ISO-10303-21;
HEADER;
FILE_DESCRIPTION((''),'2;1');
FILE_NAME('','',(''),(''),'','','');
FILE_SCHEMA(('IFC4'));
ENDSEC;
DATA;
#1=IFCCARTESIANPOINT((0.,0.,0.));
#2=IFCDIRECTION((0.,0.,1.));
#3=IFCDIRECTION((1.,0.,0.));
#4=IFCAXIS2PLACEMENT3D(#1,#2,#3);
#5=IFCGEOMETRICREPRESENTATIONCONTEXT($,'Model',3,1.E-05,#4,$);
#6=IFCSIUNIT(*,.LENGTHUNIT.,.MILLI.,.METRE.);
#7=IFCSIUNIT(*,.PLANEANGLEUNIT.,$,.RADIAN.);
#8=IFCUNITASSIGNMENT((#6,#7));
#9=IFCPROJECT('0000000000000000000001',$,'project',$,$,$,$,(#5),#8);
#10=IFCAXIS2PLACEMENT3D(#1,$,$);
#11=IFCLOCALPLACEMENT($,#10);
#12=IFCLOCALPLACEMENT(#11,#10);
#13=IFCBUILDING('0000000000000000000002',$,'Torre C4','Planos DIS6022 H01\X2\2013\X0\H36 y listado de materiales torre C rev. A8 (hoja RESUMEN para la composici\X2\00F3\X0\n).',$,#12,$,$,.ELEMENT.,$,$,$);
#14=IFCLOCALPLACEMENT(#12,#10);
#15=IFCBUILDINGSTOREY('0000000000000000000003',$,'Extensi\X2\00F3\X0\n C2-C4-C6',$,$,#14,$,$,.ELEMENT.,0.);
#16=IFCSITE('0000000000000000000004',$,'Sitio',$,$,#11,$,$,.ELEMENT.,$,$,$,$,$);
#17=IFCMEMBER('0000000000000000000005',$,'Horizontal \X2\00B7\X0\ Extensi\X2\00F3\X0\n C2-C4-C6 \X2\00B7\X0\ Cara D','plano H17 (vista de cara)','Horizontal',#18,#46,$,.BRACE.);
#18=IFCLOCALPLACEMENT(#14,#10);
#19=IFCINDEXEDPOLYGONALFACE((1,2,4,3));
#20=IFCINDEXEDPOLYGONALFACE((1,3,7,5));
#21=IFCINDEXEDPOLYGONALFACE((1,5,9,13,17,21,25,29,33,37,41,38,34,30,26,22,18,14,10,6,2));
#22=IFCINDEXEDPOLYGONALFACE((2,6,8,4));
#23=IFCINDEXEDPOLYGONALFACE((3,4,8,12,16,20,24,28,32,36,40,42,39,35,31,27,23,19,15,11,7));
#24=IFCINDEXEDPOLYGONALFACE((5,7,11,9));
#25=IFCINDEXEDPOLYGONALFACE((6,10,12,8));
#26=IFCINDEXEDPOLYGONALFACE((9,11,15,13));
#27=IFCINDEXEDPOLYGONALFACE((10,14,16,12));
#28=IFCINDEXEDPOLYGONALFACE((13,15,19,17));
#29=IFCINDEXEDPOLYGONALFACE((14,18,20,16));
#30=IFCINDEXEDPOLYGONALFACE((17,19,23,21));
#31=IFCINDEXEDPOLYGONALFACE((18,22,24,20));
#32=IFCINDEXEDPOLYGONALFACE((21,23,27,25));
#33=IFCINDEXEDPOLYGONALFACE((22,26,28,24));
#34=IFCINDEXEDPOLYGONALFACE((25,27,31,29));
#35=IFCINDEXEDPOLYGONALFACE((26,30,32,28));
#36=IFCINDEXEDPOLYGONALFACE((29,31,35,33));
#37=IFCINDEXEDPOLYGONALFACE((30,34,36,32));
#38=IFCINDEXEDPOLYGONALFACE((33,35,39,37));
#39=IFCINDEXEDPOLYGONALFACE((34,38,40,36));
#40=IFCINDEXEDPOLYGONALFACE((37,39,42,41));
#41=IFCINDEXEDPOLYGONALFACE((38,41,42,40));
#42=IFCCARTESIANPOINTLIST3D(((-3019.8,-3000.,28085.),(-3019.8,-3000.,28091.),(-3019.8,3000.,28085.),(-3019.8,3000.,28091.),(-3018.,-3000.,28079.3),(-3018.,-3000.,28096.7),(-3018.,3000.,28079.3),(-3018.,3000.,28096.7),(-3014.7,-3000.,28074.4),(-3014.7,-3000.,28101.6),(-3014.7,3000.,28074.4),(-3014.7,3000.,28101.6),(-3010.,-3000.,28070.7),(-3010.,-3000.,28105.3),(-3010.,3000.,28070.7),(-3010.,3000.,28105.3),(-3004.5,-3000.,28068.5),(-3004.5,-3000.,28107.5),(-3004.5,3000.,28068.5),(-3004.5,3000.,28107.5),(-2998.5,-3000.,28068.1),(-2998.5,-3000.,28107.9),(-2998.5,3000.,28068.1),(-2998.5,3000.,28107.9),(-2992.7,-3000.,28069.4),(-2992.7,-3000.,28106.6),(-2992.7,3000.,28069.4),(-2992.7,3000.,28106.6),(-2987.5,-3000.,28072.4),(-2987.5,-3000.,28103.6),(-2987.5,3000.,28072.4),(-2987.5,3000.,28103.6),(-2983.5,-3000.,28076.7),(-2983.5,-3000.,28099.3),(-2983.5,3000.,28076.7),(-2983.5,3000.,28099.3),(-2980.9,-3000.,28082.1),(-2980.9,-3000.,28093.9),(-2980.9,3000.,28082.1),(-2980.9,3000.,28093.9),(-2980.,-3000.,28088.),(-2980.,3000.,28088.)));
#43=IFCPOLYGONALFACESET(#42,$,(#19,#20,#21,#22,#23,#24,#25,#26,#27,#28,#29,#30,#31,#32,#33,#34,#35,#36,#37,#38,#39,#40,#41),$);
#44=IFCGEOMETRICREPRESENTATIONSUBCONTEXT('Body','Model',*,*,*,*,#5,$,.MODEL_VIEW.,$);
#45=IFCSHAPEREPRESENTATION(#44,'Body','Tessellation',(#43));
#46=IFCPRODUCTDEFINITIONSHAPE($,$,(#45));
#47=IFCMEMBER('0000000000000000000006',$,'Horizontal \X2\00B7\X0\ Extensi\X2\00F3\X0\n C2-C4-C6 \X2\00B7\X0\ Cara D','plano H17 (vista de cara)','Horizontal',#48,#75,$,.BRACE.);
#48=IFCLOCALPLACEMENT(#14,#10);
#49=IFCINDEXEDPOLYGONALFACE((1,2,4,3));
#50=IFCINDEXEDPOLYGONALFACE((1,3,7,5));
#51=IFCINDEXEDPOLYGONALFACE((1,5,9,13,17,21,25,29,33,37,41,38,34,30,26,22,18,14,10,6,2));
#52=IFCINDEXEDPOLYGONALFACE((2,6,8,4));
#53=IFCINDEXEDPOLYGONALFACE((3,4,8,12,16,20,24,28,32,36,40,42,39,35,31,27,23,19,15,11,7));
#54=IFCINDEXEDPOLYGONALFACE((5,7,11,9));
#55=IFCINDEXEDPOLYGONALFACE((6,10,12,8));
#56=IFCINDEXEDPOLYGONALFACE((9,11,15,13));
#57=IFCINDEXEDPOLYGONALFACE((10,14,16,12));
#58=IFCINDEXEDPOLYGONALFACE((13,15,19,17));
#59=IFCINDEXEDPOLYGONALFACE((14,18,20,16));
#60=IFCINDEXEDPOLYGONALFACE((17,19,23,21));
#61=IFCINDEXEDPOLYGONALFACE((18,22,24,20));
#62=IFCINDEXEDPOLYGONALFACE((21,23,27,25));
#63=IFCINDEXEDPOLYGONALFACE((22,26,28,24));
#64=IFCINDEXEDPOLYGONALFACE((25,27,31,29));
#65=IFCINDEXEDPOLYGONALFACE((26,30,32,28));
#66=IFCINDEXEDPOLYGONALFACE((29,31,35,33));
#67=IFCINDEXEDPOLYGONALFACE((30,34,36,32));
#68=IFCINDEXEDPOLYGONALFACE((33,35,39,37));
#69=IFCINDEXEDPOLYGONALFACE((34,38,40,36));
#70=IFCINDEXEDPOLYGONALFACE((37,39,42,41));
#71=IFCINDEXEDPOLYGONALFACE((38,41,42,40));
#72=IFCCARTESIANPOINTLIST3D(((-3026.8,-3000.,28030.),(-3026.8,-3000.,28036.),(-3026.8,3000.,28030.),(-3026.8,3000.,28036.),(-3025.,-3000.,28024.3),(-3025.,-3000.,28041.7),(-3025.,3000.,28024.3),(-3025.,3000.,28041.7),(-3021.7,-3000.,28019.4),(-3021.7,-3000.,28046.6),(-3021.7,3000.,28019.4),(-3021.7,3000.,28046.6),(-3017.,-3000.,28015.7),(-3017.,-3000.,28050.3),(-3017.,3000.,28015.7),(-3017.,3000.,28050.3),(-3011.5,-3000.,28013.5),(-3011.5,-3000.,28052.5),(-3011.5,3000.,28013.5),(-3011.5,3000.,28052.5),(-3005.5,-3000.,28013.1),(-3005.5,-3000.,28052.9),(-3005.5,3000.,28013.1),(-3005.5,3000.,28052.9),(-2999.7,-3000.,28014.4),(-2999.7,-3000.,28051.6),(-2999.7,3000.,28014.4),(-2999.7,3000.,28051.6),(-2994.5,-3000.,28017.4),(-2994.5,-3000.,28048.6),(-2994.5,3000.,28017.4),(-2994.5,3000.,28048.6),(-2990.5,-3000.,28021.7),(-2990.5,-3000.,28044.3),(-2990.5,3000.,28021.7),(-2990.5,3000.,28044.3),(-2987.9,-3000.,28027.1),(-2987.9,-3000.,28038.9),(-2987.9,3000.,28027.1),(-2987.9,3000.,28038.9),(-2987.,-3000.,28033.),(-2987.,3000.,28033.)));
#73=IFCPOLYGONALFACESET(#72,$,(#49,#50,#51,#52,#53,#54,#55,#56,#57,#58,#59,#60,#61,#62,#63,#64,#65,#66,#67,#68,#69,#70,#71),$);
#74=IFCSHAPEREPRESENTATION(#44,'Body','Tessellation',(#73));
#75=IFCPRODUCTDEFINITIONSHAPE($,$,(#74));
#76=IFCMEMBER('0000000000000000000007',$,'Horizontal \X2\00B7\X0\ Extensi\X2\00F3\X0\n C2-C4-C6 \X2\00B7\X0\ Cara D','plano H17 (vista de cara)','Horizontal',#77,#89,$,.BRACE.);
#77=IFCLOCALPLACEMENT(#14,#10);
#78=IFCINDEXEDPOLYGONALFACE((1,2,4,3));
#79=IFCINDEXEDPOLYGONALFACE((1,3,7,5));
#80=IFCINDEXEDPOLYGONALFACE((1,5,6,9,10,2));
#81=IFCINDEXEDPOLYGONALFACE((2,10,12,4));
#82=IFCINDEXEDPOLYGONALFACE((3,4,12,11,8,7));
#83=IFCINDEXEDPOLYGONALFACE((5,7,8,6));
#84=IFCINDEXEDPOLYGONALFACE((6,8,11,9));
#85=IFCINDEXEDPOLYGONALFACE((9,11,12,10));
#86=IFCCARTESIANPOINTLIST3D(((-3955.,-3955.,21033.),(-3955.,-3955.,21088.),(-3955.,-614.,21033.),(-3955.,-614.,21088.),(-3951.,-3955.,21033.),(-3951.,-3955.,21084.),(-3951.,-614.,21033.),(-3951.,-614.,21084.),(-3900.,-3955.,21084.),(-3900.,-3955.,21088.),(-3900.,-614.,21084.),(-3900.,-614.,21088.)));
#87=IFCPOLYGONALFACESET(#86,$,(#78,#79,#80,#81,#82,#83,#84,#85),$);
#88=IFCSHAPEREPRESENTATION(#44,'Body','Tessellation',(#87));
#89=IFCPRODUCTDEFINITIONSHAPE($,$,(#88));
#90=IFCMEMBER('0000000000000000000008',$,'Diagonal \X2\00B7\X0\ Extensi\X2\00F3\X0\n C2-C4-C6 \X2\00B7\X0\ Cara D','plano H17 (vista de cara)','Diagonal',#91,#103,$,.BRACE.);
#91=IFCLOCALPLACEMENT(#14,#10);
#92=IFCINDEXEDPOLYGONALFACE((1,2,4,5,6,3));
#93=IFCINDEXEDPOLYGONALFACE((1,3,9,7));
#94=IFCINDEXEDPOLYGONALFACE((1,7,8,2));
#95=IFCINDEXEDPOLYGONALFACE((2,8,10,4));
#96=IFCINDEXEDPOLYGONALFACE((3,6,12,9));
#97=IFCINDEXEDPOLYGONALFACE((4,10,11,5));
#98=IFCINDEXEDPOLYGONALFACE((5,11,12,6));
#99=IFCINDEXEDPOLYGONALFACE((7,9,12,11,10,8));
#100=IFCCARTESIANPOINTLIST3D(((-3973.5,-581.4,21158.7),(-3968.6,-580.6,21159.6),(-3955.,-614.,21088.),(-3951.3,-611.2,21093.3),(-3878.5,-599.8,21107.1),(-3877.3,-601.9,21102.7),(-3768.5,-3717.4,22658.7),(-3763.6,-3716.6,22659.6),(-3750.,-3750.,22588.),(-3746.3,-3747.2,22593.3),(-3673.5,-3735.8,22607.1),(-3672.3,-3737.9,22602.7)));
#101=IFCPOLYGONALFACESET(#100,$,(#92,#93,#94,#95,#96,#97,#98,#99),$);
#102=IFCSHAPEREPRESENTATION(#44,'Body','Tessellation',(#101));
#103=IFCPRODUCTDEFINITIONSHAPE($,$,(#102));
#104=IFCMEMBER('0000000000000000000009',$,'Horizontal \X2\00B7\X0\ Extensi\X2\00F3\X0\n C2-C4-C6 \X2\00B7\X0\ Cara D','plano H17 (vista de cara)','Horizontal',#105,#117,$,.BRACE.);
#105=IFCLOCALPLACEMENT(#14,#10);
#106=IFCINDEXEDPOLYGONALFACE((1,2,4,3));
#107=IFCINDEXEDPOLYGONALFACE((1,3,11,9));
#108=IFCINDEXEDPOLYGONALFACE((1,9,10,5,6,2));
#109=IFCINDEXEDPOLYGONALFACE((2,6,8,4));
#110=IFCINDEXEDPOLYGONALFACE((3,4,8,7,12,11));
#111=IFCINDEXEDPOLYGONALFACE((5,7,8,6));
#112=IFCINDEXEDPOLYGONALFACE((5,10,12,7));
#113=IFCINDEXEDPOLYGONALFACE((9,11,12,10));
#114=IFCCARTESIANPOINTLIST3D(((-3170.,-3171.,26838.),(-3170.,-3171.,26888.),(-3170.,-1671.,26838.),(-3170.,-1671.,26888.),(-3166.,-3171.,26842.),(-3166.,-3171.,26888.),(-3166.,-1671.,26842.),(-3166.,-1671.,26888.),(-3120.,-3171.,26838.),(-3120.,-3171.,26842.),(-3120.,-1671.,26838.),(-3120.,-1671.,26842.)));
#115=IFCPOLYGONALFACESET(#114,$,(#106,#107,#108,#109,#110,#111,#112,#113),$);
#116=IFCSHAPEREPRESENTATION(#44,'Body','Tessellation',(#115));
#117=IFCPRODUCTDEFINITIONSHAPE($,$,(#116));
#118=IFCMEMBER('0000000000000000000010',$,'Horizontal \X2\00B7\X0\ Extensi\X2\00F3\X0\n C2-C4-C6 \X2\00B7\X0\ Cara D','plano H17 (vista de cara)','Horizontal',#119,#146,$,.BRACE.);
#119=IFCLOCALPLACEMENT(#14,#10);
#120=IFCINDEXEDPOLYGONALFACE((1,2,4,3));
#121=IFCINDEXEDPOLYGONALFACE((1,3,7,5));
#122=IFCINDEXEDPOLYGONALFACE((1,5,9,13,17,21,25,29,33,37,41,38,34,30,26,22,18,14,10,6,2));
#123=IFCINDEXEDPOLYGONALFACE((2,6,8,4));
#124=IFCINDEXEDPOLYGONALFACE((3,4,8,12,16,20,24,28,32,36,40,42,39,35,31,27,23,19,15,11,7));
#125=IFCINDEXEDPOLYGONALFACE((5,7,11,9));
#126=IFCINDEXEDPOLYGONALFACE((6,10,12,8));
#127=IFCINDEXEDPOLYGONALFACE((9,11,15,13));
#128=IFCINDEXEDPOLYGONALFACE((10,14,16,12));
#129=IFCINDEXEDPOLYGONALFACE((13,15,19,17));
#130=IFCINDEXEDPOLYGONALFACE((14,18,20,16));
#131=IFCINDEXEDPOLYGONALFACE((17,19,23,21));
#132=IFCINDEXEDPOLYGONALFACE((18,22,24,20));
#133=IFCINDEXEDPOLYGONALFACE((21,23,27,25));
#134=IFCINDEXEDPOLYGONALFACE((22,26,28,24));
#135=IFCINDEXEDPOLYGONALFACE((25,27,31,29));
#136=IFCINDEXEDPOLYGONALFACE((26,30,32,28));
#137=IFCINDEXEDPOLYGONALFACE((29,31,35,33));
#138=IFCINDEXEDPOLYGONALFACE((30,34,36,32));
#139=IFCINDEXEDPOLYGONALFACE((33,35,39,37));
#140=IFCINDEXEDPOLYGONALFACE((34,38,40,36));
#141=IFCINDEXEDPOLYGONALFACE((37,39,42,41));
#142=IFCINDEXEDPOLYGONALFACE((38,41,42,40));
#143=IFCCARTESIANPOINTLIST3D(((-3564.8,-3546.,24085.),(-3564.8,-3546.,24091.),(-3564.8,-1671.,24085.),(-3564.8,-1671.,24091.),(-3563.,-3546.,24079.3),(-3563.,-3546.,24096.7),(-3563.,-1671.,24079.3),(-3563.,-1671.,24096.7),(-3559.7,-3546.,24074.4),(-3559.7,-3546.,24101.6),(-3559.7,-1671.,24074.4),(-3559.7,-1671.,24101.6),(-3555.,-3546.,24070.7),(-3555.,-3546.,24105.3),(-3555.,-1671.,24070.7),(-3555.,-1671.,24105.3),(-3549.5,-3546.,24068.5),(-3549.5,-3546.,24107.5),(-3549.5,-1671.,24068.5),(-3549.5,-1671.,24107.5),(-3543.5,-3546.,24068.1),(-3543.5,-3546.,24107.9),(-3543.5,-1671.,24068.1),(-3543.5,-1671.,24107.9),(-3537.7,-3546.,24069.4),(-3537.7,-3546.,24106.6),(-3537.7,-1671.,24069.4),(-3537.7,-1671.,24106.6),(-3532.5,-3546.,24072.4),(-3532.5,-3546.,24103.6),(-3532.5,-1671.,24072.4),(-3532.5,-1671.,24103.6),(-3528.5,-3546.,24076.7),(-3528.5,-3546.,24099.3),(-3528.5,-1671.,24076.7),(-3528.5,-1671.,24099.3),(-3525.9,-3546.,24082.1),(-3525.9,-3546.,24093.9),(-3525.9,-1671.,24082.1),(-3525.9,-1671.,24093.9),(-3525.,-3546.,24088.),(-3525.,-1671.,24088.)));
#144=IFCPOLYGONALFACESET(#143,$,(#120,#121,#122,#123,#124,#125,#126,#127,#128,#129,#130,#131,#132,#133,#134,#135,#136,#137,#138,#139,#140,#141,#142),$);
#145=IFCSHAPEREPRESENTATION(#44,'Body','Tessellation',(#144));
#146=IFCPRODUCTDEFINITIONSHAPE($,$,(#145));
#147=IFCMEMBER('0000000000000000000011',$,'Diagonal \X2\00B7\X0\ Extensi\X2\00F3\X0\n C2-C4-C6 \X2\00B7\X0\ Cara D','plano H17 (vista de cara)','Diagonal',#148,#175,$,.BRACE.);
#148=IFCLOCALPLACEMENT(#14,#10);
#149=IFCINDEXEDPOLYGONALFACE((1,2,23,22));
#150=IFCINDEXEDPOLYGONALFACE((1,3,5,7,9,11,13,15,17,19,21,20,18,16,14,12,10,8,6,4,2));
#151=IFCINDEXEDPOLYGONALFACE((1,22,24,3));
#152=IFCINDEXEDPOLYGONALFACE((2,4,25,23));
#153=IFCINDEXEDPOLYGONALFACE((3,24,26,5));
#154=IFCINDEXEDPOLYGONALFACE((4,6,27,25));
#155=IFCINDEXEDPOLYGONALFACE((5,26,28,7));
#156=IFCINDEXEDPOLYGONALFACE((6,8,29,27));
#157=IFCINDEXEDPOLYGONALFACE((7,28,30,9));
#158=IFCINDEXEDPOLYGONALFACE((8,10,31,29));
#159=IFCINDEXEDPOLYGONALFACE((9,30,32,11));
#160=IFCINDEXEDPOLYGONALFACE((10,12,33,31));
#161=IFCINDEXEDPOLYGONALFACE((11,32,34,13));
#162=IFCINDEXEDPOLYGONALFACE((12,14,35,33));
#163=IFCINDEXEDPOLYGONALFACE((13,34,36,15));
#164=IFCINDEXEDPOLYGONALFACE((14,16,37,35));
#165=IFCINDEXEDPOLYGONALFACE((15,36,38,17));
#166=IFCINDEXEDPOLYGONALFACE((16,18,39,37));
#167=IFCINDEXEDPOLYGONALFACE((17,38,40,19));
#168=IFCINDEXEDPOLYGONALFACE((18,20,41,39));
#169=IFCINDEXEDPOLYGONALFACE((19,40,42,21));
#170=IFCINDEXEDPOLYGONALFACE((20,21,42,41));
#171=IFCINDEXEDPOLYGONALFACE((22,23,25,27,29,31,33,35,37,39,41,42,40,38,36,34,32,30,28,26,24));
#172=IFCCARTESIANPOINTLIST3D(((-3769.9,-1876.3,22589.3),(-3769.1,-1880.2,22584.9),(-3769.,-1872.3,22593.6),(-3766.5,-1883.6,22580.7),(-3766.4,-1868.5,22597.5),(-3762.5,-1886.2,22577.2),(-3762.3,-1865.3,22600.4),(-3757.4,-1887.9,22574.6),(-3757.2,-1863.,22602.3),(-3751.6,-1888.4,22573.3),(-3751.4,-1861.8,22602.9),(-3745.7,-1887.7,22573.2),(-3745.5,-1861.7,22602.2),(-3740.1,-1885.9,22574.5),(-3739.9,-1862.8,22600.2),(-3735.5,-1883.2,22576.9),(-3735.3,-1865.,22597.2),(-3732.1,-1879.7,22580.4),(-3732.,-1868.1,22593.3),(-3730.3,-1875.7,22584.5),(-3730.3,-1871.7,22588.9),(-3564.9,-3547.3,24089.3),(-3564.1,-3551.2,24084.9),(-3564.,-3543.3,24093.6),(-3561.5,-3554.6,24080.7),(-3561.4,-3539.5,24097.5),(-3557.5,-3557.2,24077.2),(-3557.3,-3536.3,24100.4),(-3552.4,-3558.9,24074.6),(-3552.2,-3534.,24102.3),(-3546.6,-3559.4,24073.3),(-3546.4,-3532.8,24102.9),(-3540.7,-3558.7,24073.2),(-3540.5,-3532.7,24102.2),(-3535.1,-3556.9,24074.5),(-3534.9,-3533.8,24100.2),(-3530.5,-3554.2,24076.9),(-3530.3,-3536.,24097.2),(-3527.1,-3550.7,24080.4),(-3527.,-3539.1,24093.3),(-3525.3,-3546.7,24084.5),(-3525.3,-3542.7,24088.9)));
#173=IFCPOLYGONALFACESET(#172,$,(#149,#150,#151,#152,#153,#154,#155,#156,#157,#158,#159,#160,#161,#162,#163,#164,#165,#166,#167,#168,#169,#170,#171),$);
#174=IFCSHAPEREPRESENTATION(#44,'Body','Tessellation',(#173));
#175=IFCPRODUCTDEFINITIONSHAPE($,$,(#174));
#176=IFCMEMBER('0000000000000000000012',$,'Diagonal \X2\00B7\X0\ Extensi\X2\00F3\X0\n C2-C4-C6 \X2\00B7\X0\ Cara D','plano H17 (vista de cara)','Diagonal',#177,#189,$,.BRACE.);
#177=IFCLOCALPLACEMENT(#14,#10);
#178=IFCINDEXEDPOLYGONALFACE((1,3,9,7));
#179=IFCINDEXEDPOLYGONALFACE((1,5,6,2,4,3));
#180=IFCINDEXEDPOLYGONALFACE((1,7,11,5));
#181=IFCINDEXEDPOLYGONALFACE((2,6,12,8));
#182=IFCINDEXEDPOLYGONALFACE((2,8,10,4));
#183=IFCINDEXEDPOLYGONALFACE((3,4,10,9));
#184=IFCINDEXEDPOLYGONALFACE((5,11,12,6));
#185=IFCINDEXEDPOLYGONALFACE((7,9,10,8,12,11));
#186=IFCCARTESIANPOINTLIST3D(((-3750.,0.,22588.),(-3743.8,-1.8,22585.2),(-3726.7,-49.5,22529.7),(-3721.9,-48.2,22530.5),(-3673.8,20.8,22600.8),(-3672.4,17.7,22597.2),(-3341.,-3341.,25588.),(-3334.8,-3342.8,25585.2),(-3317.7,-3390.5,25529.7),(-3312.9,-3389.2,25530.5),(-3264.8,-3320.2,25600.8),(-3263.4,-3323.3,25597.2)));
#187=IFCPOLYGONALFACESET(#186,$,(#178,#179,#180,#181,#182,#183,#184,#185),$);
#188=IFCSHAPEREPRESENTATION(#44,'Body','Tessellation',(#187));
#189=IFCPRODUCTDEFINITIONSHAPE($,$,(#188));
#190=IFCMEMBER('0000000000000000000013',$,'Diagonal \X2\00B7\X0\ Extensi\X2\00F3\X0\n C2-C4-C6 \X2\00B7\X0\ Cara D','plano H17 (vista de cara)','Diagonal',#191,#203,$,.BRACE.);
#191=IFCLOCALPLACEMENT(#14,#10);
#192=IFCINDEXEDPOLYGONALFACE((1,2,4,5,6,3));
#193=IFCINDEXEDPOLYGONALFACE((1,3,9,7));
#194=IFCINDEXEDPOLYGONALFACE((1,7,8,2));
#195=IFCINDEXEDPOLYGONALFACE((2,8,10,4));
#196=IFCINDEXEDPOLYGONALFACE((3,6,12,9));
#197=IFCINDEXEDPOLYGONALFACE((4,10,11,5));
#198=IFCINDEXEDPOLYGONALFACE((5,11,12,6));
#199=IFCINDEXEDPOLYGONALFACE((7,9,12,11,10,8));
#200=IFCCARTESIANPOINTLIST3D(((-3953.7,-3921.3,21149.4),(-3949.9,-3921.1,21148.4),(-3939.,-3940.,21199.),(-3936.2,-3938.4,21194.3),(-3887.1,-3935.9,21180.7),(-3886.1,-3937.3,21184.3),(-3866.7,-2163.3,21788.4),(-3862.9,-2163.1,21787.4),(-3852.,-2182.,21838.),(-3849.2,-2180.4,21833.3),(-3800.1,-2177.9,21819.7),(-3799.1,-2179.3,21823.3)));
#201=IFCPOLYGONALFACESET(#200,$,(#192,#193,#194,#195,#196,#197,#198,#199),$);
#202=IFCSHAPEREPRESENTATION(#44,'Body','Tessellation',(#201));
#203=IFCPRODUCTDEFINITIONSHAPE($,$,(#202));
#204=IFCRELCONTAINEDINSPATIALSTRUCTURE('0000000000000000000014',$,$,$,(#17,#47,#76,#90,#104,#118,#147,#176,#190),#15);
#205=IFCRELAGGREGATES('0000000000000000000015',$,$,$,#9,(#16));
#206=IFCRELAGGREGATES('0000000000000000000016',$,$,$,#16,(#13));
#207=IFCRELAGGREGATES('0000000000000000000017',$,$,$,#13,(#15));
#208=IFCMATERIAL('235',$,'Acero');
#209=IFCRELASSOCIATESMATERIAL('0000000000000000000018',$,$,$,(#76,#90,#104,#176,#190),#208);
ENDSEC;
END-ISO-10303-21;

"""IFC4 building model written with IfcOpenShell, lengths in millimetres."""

from ifc_helpers import new_model, si_unit, frame, frame_2d, origin, origin_with_axes, place, context, subcontext, project, spatial, circle, l_section, extrude, material, element, save


model = new_model("IFC4")

# Units and contexts
model_context = context("Model", 3, precision=1e-05, world=origin_with_axes())
body_context = subcontext(model_context, "Body", "Model", "MODEL_VIEW")
ifc_project = project(units=[si_unit("LENGTHUNIT", "METRE", prefix="MILLI"), si_unit("PLANEANGLEUNIT", "RADIAN")], contexts=[model_context])

# Site, building, storey
site_placement = place(None, origin())
site = spatial("IfcSite", under=ifc_project, at=site_placement, Name="Sitio", CompositionType="ELEMENT")
building_placement = place(site_placement, origin())
building = spatial("IfcBuilding", under=site, at=building_placement, Name="Torre C4", Description="Planos DIS6022 H01–H36 y listado de materiales torre C rev. A8 (hoja RESUMEN para la composición).", CompositionType="ELEMENT")
storey_placement = place(building_placement, origin())
storey = spatial("IfcBuildingStorey", under=building, at=storey_placement, Name="Extensión C2-C4-C6", CompositionType="ELEMENT", Elevation=0.0)

# Members
ifc_material_1 = material(Name="235", Category="Acero")
for number, where, z_axis, x_axis, name in (
    (1, (-3000.0, -3000.0, 28088.0), (0.0, 1.0, 0.0), (1.0, 0.0, 0.0), "Horizontal · Extensión C2-C4-C6 · Cara D"),
    (2, (-3007.0, -3000.0, 28033.0), (0.0, 1.0, 0.0), (1.0, 0.0, 0.0), "Horizontal · Extensión C2-C4-C6 · Cara D"),
):
    element("IfcMember", number, at=place(storey_placement, frame(where, z_axis=z_axis, x_axis=x_axis)), inside=storey, Name=name, Description="plano H17 (vista de cara)", ObjectType="Horizontal", PredefinedType="BRACE", context=body_context, shape_type="SweptSolid", body=[
        extrude(circle(Radius=20.0), None, (0.0, 0.0, 1.0), 6000.0),
    ])
member_1_placement = place(storey_placement, frame((-3955.0, -3955.0, 21088.0), z_axis=(0.0, 1.0, 0.0), x_axis=(1.0, 0.0, 0.0)))
element("IfcMember", 3, at=member_1_placement, inside=storey, material=ifc_material_1, Name="Horizontal · Extensión C2-C4-C6 · Cara D", Description="plano H17 (vista de cara)", ObjectType="Horizontal", PredefinedType="BRACE", context=body_context, shape_type="SweptSolid", body=[
    extrude(l_section(Depth=55.0, Width=55.0, Thickness=4.0, at=frame_2d((27.5, 27.5))), None, (0.0, 0.0, 1.0), 3341.0),
])
member_2_placement = place(storey_placement, frame((-3955.0, -614.0, 21088.0), z_axis=(0.058869, -0.90055, 0.430748), x_axis=(0.971215, 0.151437, 0.183871)))
element("IfcMember", 4, at=member_2_placement, inside=storey, material=ifc_material_1, Name="Diagonal · Extensión C2-C4-C6 · Cara D", Description="plano H17 (vista de cara)", ObjectType="Diagonal", PredefinedType="BRACE", context=body_context, shape_type="SweptSolid", body=[
    extrude(l_section(Depth=80.0, Width=80.0, Thickness=5.0, at=frame_2d((40.0, 40.0))), None, (0.0, 0.0, 1.0), 3482.3),
])
member_3_placement = place(storey_placement, frame((-3170.0, -1671.0, 26838.0), z_axis=(0.0, -1.0, 0.0), x_axis=(1.0, 0.0, 0.0)))
element("IfcMember", 5, at=member_3_placement, inside=storey, material=ifc_material_1, Name="Horizontal · Extensión C2-C4-C6 · Cara D", Description="plano H17 (vista de cara)", ObjectType="Horizontal", PredefinedType="BRACE", context=body_context, shape_type="SweptSolid", body=[
    extrude(l_section(Depth=50.0, Width=50.0, Thickness=4.0, at=frame_2d((25.0, 25.0))), None, (0.0, 0.0, 1.0), 1500.0),
])
member_4_placement = place(storey_placement, frame((-3545.0, -1671.0, 24088.0), z_axis=(0.0, -1.0, 0.0), x_axis=(1.0, 0.0, 0.0)))
element("IfcMember", 6, at=member_4_placement, inside=storey, Name="Horizontal · Extensión C2-C4-C6 · Cara D", Description="plano H17 (vista de cara)", ObjectType="Horizontal", PredefinedType="BRACE", context=body_context, shape_type="SweptSolid", body=[
    extrude(circle(Radius=20.0), None, (0.0, 0.0, 1.0), 1875.0),
])
member_5_placement = place(storey_placement, frame((-3545.0, -3546.0, 24088.0), z_axis=(-0.090916, 0.741075, -0.665238), x_axis=(0.899707, 0.347494, 0.264149)))
element("IfcMember", 7, at=member_5_placement, inside=storey, Name="Diagonal · Extensión C2-C4-C6 · Cara D", Description="plano H17 (vista de cara)", ObjectType="Diagonal", PredefinedType="BRACE", context=body_context, shape_type="SweptSolid", body=[
    extrude(circle(Radius=20.0), None, (0.0, 0.0, 1.0), 2254.8),
])
member_6_placement = place(storey_placement, frame((-3341.0, -3341.0, 25588.0), z_axis=(-0.090711, 0.74099, -0.665361), x_axis=(0.952207, 0.260212, 0.159972)))
element("IfcMember", 8, at=member_6_placement, inside=storey, material=ifc_material_1, Name="Diagonal · Extensión C2-C4-C6 · Cara D", Description="plano H17 (vista de cara)", ObjectType="Diagonal", PredefinedType="BRACE", context=body_context, shape_type="SweptSolid", body=[
    extrude(l_section(Depth=80.0, Width=80.0, Thickness=5.0, at=frame_2d((40.0, 40.0))), None, (0.0, 0.0, 1.0), 4508.8),
])
member_7_placement = place(storey_placement, frame((-3939.0, -3940.0, 21199.0), z_axis=(0.046461, 0.938825, 0.341245), x_axis=(0.962352, 0.049518, -0.267257)))
element("IfcMember", 9, at=member_7_placement, inside=storey, material=ifc_material_1, Name="Diagonal · Extensión C2-C4-C6 · Cara D", Description="plano H17 (vista de cara)", ObjectType="Diagonal", PredefinedType="BRACE", context=body_context, shape_type="SweptSolid", body=[
    extrude(l_section(Depth=55.0, Width=55.0, Thickness=4.0, at=frame_2d((27.5, 27.5))), None, (0.0, 0.0, 1.0), 1872.6),
])

save(model, "model.ifc")
